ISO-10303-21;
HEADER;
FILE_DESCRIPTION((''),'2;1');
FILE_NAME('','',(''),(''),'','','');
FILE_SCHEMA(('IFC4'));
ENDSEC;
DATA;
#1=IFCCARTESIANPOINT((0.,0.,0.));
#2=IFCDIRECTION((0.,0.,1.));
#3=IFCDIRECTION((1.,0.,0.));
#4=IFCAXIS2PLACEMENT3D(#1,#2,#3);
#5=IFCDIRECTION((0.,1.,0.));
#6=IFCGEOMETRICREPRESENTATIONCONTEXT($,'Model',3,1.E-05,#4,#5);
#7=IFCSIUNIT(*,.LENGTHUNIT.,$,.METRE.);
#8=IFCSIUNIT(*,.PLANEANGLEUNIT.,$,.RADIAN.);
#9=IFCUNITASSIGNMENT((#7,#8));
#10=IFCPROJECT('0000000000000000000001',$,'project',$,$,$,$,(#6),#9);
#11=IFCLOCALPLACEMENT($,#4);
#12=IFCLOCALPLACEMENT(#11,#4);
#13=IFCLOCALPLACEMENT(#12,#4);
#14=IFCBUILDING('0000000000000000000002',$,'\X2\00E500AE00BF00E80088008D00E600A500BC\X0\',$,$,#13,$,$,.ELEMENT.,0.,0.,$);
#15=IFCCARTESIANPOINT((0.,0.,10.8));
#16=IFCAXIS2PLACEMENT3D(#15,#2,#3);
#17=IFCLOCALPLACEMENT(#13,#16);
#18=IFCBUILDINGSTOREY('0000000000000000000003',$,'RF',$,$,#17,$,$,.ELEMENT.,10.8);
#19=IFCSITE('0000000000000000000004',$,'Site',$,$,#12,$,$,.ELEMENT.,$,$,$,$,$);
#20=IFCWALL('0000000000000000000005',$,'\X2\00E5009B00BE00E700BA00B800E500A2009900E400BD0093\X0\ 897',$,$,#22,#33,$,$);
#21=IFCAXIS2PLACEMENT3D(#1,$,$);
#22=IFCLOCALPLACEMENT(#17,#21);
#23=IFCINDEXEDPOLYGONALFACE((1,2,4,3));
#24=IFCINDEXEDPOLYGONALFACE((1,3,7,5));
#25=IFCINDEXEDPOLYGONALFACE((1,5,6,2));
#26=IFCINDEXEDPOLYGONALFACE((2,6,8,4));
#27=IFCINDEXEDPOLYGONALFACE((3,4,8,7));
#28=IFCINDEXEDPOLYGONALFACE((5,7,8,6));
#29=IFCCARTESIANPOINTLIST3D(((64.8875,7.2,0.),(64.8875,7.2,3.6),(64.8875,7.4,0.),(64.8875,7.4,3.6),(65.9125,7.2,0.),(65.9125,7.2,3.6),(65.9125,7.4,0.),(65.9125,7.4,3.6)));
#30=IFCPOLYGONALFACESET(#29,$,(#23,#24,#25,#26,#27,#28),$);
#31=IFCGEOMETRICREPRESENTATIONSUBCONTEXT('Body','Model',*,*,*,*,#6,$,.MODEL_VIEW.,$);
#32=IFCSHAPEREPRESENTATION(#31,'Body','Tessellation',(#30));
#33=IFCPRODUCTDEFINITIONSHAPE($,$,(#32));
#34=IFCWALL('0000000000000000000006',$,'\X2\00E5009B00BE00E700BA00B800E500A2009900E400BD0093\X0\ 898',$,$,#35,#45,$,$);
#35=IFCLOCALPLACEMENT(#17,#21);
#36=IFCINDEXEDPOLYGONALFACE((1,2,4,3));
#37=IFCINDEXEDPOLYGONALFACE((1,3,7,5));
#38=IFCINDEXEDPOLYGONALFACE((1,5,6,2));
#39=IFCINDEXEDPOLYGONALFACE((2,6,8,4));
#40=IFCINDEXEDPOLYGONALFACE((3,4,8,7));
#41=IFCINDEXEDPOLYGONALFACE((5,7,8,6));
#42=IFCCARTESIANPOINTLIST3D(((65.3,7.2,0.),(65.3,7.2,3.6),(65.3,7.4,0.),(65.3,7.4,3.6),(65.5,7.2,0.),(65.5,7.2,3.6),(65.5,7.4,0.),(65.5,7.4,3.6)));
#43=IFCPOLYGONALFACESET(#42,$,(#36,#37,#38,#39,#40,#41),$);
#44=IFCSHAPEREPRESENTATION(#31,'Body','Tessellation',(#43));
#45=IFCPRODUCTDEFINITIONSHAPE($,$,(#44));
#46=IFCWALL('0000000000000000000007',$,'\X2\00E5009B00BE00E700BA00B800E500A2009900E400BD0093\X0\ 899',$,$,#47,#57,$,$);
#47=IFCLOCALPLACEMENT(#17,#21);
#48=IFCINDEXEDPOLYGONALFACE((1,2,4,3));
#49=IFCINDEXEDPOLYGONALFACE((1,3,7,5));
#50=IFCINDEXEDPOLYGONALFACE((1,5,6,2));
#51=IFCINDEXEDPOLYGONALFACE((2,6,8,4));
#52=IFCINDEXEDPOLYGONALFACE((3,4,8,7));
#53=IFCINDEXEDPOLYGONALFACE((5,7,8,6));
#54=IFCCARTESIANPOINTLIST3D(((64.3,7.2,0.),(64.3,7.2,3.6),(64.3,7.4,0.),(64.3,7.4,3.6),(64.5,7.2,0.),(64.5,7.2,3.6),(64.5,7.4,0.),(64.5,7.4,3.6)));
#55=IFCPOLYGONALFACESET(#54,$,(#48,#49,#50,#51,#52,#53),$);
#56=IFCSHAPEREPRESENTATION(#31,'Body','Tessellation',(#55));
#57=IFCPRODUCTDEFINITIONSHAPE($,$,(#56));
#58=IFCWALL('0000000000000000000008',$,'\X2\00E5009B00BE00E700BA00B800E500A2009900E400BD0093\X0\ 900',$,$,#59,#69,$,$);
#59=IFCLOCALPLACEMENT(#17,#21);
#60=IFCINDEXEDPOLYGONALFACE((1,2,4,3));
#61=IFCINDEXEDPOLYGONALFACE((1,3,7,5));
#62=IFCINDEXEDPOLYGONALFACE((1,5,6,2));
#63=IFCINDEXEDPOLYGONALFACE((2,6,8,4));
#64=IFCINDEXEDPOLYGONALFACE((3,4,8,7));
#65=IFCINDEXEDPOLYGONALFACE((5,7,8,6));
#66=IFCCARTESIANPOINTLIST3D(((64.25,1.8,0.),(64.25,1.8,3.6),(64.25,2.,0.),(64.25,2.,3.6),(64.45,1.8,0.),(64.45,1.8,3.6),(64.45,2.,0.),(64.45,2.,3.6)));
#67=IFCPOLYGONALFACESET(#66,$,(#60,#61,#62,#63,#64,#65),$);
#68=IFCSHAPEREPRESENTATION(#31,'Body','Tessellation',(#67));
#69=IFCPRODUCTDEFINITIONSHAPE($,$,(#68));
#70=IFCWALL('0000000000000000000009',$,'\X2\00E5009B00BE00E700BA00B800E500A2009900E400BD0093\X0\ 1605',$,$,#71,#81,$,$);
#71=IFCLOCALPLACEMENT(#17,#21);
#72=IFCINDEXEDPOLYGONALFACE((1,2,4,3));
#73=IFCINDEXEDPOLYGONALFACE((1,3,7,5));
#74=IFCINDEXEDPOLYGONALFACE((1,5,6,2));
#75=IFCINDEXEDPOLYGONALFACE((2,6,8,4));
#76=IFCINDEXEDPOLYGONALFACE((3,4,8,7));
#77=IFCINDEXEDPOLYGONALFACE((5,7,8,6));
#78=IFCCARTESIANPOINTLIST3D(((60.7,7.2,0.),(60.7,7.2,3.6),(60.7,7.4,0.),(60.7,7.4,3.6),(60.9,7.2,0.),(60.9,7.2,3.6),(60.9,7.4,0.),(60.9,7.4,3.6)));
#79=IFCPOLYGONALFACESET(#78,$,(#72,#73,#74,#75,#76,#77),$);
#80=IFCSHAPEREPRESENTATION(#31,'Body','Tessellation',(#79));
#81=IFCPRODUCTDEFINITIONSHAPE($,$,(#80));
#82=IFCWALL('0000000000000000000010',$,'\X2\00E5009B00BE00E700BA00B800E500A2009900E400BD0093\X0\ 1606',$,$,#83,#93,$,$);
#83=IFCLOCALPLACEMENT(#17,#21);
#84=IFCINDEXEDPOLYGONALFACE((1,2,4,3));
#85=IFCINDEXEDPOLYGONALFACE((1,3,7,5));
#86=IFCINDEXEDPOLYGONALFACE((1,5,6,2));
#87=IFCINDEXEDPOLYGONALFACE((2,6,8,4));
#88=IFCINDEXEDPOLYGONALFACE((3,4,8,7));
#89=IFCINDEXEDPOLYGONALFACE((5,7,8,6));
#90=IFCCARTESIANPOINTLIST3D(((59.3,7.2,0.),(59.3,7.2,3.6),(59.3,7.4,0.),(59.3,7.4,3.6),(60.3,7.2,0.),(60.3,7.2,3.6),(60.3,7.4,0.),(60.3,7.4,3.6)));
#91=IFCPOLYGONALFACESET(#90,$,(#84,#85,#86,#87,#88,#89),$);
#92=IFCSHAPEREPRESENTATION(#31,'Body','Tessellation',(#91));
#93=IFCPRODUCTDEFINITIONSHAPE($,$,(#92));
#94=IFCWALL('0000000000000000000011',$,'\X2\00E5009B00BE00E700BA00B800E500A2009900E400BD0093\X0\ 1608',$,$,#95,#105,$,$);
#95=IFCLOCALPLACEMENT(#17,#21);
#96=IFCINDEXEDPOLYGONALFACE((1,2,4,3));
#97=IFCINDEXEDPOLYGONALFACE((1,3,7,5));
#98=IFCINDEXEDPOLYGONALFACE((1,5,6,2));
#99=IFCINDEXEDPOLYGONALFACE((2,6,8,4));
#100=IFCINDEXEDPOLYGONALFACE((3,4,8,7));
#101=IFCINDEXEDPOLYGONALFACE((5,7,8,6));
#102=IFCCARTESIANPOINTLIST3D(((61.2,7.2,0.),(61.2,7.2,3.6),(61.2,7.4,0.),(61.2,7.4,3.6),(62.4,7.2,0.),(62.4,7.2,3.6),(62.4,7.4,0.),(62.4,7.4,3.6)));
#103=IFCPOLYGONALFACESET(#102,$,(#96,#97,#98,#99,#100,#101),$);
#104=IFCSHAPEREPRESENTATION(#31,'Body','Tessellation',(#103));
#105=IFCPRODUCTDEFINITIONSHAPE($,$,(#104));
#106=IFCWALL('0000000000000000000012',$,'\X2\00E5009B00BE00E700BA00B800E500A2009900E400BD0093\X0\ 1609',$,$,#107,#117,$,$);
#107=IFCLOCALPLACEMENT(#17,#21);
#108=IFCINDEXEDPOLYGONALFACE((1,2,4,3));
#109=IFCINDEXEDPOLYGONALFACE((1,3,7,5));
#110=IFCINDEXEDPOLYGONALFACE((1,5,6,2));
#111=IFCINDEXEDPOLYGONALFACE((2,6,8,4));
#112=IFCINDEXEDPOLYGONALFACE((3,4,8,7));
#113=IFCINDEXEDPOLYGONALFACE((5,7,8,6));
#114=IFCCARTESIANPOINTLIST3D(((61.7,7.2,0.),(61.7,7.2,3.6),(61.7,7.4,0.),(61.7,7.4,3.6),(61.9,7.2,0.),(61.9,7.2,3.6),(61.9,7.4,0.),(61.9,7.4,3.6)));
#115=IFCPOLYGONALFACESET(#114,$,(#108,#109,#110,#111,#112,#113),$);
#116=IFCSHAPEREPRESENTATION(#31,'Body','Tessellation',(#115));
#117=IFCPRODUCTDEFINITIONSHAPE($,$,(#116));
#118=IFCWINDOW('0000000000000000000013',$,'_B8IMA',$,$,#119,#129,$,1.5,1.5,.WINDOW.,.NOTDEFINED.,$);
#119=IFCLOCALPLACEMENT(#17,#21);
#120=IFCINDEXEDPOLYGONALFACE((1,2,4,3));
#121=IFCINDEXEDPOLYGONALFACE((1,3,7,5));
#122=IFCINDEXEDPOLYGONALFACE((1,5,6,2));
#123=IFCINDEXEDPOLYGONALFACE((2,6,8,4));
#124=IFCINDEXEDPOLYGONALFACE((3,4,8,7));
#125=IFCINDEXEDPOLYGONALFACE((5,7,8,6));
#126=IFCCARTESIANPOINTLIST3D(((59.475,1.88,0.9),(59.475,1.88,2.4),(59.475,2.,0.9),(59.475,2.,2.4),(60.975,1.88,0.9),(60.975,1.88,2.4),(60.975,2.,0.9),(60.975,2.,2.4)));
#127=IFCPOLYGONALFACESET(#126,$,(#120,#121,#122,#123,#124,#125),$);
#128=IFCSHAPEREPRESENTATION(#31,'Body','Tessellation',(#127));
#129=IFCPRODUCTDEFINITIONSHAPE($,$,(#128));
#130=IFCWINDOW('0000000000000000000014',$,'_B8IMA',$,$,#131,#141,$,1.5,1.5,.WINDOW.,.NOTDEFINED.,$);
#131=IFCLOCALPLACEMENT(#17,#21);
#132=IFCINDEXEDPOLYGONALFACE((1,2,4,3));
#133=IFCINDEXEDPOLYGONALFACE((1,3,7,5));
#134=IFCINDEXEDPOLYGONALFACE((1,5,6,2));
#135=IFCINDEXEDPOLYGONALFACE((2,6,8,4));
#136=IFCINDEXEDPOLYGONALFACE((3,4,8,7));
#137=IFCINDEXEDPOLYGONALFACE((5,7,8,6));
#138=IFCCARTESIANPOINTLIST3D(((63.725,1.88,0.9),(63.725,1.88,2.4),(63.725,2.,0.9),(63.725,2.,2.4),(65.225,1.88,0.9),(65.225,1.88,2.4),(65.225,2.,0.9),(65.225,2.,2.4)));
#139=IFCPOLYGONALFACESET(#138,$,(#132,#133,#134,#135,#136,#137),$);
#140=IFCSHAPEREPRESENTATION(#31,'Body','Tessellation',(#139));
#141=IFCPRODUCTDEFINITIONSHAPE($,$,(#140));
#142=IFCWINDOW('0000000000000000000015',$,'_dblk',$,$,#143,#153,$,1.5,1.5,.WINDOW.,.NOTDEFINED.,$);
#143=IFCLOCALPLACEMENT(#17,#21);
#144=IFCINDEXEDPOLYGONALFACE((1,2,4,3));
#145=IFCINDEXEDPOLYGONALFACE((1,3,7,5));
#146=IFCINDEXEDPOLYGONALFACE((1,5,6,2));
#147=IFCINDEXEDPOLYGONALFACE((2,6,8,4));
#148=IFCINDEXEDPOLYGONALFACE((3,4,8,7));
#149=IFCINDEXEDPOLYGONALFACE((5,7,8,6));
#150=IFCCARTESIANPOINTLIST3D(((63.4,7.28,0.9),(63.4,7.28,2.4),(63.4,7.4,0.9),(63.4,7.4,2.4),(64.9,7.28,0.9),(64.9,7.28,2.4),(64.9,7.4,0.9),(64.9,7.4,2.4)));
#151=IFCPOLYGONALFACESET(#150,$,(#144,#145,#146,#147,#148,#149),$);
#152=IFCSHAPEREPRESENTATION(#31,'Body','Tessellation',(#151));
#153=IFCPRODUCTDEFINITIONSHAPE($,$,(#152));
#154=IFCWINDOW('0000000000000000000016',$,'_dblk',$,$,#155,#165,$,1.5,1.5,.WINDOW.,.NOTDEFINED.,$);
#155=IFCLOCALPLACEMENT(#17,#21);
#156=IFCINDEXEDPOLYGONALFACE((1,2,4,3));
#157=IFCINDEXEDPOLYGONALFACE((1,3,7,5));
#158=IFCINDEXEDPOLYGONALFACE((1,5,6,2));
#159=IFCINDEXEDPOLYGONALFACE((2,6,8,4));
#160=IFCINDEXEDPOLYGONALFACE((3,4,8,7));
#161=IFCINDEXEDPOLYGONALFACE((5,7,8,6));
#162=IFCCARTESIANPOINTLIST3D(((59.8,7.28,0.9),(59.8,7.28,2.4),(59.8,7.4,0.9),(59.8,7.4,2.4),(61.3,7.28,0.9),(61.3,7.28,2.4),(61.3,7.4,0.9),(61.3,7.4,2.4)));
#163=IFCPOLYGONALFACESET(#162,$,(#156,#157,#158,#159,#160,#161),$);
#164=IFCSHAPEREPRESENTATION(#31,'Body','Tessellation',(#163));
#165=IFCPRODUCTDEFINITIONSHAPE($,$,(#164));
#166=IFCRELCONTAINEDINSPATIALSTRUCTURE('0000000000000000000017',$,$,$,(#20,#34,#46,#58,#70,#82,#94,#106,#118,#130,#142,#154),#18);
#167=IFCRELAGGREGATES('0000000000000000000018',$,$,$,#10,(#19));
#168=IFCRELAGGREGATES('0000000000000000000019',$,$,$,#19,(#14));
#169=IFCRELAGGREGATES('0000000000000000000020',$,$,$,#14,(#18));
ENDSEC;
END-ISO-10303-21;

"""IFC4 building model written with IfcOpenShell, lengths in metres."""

from ifc_helpers import new_model, si_unit, direction, frame, frame_2d, origin_with_axes, place, context, subcontext, project, spatial, rectangle, extrude, element, save


model = new_model("IFC4")

# Units and contexts
model_context = context("Model", 3, precision=1e-05, world=origin_with_axes(), true_north=direction((0.0, 1.0, 0.0)))
body_context = subcontext(model_context, "Body", "Model", "MODEL_VIEW")
ifc_project = project(units=[si_unit("LENGTHUNIT", "METRE"), si_unit("PLANEANGLEUNIT", "RADIAN")], contexts=[model_context])

# Site, building, storey
placement = place(None, origin_with_axes())
site_placement = place(placement, origin_with_axes())
site = spatial("IfcSite", under=ifc_project, at=site_placement, Name="Site", CompositionType="ELEMENT")
building_placement = place(site_placement, origin_with_axes())
building = spatial("IfcBuilding", under=site, at=building_placement, Name="å®¿è\u0088\u008dæ¥¼", CompositionType="ELEMENT", ElevationOfRefHeight=0.0, ElevationOfTerrain=0.0)
storey_placement = place(building_placement, frame((0.0, 0.0, 10.8), z_axis=(0.0, 0.0, 1.0), x_axis=(1.0, 0.0, 0.0)))
storey = spatial("IfcBuildingStorey", under=building, at=storey_placement, Name="RF", CompositionType="ELEMENT", Elevation=10.8)

# Walls
wall_1_placement = place(storey_placement, frame((65.4, 7.3, 0.0), z_axis=(0.0, 0.0, 1.0), x_axis=(1.0, 0.0, 0.0)))
element("IfcWall", 1, at=wall_1_placement, inside=storey, Name="å\u009b¾çº¸å¢\u0099ä½\u0093 897", context=body_context, shape_type="SweptSolid", body=[
    extrude(rectangle(XDim=1.025, YDim=0.2, at=frame_2d((0.0, 0.0), x_axis=(1.0, 0.0, 0.0))), frame((0.0, 0.0, 0.0), z_axis=(0.0, 0.0, 1.0)), (0.0, 0.0, 1.0), 3.6),
])
for number, where, z_axis, x_axis, name in (
    (2, (65.4, 7.3, 0.0), (0.0, 0.0, 1.0), (0.0, 1.0, 0.0), "å\u009b¾çº¸å¢\u0099ä½\u0093 898"),
    (3, (64.4, 7.3, 0.0), (0.0, 0.0, 1.0), (0.0, 1.0, 0.0), "å\u009b¾çº¸å¢\u0099ä½\u0093 899"),
    (4, (64.35, 1.9, 0.0), (0.0, 0.0, 1.0), (0.0, 1.0, 0.0), "å\u009b¾çº¸å¢\u0099ä½\u0093 900"),
    (5, (60.8, 7.3, 0.0), (0.0, 0.0, 1.0), (0.0, 1.0, 0.0), "å\u009b¾çº¸å¢\u0099ä½\u0093 1605"),
):
    element("IfcWall", number, at=place(storey_placement, frame(where, z_axis=z_axis, x_axis=x_axis)), inside=storey, Name=name, context=body_context, shape_type="SweptSolid", body=[
        extrude(rectangle(XDim=0.2, YDim=0.2, at=frame_2d((0.0, 0.0), x_axis=(1.0, 0.0, 0.0))), frame((0.0, 0.0, 0.0), z_axis=(0.0, 0.0, 1.0)), (0.0, 0.0, 1.0), 3.6),
    ])
wall_2_placement = place(storey_placement, frame((59.8, 7.3, 0.0), z_axis=(0.0, 0.0, 1.0), x_axis=(1.0, 0.0, 0.0)))
element("IfcWall", 6, at=wall_2_placement, inside=storey, Name="å\u009b¾çº¸å¢\u0099ä½\u0093 1606", context=body_context, shape_type="SweptSolid", body=[
    extrude(rectangle(XDim=1.0, YDim=0.2, at=frame_2d((0.0, 0.0), x_axis=(1.0, 0.0, 0.0))), frame((0.0, 0.0, 0.0), z_axis=(0.0, 0.0, 1.0)), (0.0, 0.0, 1.0), 3.6),
])
wall_3_placement = place(storey_placement, frame((61.8, 7.3, 0.0), z_axis=(0.0, 0.0, 1.0), x_axis=(1.0, 0.0, 0.0)))
element("IfcWall", 7, at=wall_3_placement, inside=storey, Name="å\u009b¾çº¸å¢\u0099ä½\u0093 1608", context=body_context, shape_type="SweptSolid", body=[
    extrude(rectangle(XDim=1.2, YDim=0.2, at=frame_2d((0.0, 0.0), x_axis=(1.0, 0.0, 0.0))), frame((0.0, 0.0, 0.0), z_axis=(0.0, 0.0, 1.0)), (0.0, 0.0, 1.0), 3.6),
])
wall_4_placement = place(storey_placement, frame((61.8, 7.3, 0.0), z_axis=(0.0, 0.0, 1.0), x_axis=(0.0, 1.0, 0.0)))
element("IfcWall", 8, at=wall_4_placement, inside=storey, Name="å\u009b¾çº¸å¢\u0099ä½\u0093 1609", context=body_context, shape_type="SweptSolid", body=[
    extrude(rectangle(XDim=0.2, YDim=0.2, at=frame_2d((0.0, 0.0), x_axis=(1.0, 0.0, 0.0))), frame((0.0, 0.0, 0.0), z_axis=(0.0, 0.0, 1.0)), (0.0, 0.0, 1.0), 3.6),
])

# Windows
for number, where, z_axis, x_axis, name in (
    (9, (60.225, 1.94, 0.9), (0.0, 0.0, 1.0), (1.0, 0.0, 0.0), "_B8IMA"),
    (10, (64.475, 1.94, 0.9), (0.0, 0.0, 1.0), (1.0, 0.0, 0.0), "_B8IMA"),
    (11, (64.15, 7.34, 0.9), (0.0, 0.0, 1.0), (1.0, 0.0, 0.0), "_dblk"),
    (12, (60.55, 7.34, 0.9), (0.0, 0.0, 1.0), (1.0, 0.0, 0.0), "_dblk"),
):
    element("IfcWindow", number, at=place(storey_placement, frame(where, z_axis=z_axis, x_axis=x_axis)), inside=storey, Name=name, OverallHeight=1.5, OverallWidth=1.5, PartitioningType="NOTDEFINED", PredefinedType="WINDOW", context=body_context, shape_type="SweptSolid", body=[
        extrude(rectangle(XDim=1.5, YDim=0.12, at=frame_2d((0.0, 0.0), x_axis=(1.0, 0.0, 0.0))), frame((0.0, 0.0, 0.0), z_axis=(0.0, 0.0, 1.0)), (0.0, 0.0, 1.0), 1.5),
    ])

save(model, "model.ifc")
